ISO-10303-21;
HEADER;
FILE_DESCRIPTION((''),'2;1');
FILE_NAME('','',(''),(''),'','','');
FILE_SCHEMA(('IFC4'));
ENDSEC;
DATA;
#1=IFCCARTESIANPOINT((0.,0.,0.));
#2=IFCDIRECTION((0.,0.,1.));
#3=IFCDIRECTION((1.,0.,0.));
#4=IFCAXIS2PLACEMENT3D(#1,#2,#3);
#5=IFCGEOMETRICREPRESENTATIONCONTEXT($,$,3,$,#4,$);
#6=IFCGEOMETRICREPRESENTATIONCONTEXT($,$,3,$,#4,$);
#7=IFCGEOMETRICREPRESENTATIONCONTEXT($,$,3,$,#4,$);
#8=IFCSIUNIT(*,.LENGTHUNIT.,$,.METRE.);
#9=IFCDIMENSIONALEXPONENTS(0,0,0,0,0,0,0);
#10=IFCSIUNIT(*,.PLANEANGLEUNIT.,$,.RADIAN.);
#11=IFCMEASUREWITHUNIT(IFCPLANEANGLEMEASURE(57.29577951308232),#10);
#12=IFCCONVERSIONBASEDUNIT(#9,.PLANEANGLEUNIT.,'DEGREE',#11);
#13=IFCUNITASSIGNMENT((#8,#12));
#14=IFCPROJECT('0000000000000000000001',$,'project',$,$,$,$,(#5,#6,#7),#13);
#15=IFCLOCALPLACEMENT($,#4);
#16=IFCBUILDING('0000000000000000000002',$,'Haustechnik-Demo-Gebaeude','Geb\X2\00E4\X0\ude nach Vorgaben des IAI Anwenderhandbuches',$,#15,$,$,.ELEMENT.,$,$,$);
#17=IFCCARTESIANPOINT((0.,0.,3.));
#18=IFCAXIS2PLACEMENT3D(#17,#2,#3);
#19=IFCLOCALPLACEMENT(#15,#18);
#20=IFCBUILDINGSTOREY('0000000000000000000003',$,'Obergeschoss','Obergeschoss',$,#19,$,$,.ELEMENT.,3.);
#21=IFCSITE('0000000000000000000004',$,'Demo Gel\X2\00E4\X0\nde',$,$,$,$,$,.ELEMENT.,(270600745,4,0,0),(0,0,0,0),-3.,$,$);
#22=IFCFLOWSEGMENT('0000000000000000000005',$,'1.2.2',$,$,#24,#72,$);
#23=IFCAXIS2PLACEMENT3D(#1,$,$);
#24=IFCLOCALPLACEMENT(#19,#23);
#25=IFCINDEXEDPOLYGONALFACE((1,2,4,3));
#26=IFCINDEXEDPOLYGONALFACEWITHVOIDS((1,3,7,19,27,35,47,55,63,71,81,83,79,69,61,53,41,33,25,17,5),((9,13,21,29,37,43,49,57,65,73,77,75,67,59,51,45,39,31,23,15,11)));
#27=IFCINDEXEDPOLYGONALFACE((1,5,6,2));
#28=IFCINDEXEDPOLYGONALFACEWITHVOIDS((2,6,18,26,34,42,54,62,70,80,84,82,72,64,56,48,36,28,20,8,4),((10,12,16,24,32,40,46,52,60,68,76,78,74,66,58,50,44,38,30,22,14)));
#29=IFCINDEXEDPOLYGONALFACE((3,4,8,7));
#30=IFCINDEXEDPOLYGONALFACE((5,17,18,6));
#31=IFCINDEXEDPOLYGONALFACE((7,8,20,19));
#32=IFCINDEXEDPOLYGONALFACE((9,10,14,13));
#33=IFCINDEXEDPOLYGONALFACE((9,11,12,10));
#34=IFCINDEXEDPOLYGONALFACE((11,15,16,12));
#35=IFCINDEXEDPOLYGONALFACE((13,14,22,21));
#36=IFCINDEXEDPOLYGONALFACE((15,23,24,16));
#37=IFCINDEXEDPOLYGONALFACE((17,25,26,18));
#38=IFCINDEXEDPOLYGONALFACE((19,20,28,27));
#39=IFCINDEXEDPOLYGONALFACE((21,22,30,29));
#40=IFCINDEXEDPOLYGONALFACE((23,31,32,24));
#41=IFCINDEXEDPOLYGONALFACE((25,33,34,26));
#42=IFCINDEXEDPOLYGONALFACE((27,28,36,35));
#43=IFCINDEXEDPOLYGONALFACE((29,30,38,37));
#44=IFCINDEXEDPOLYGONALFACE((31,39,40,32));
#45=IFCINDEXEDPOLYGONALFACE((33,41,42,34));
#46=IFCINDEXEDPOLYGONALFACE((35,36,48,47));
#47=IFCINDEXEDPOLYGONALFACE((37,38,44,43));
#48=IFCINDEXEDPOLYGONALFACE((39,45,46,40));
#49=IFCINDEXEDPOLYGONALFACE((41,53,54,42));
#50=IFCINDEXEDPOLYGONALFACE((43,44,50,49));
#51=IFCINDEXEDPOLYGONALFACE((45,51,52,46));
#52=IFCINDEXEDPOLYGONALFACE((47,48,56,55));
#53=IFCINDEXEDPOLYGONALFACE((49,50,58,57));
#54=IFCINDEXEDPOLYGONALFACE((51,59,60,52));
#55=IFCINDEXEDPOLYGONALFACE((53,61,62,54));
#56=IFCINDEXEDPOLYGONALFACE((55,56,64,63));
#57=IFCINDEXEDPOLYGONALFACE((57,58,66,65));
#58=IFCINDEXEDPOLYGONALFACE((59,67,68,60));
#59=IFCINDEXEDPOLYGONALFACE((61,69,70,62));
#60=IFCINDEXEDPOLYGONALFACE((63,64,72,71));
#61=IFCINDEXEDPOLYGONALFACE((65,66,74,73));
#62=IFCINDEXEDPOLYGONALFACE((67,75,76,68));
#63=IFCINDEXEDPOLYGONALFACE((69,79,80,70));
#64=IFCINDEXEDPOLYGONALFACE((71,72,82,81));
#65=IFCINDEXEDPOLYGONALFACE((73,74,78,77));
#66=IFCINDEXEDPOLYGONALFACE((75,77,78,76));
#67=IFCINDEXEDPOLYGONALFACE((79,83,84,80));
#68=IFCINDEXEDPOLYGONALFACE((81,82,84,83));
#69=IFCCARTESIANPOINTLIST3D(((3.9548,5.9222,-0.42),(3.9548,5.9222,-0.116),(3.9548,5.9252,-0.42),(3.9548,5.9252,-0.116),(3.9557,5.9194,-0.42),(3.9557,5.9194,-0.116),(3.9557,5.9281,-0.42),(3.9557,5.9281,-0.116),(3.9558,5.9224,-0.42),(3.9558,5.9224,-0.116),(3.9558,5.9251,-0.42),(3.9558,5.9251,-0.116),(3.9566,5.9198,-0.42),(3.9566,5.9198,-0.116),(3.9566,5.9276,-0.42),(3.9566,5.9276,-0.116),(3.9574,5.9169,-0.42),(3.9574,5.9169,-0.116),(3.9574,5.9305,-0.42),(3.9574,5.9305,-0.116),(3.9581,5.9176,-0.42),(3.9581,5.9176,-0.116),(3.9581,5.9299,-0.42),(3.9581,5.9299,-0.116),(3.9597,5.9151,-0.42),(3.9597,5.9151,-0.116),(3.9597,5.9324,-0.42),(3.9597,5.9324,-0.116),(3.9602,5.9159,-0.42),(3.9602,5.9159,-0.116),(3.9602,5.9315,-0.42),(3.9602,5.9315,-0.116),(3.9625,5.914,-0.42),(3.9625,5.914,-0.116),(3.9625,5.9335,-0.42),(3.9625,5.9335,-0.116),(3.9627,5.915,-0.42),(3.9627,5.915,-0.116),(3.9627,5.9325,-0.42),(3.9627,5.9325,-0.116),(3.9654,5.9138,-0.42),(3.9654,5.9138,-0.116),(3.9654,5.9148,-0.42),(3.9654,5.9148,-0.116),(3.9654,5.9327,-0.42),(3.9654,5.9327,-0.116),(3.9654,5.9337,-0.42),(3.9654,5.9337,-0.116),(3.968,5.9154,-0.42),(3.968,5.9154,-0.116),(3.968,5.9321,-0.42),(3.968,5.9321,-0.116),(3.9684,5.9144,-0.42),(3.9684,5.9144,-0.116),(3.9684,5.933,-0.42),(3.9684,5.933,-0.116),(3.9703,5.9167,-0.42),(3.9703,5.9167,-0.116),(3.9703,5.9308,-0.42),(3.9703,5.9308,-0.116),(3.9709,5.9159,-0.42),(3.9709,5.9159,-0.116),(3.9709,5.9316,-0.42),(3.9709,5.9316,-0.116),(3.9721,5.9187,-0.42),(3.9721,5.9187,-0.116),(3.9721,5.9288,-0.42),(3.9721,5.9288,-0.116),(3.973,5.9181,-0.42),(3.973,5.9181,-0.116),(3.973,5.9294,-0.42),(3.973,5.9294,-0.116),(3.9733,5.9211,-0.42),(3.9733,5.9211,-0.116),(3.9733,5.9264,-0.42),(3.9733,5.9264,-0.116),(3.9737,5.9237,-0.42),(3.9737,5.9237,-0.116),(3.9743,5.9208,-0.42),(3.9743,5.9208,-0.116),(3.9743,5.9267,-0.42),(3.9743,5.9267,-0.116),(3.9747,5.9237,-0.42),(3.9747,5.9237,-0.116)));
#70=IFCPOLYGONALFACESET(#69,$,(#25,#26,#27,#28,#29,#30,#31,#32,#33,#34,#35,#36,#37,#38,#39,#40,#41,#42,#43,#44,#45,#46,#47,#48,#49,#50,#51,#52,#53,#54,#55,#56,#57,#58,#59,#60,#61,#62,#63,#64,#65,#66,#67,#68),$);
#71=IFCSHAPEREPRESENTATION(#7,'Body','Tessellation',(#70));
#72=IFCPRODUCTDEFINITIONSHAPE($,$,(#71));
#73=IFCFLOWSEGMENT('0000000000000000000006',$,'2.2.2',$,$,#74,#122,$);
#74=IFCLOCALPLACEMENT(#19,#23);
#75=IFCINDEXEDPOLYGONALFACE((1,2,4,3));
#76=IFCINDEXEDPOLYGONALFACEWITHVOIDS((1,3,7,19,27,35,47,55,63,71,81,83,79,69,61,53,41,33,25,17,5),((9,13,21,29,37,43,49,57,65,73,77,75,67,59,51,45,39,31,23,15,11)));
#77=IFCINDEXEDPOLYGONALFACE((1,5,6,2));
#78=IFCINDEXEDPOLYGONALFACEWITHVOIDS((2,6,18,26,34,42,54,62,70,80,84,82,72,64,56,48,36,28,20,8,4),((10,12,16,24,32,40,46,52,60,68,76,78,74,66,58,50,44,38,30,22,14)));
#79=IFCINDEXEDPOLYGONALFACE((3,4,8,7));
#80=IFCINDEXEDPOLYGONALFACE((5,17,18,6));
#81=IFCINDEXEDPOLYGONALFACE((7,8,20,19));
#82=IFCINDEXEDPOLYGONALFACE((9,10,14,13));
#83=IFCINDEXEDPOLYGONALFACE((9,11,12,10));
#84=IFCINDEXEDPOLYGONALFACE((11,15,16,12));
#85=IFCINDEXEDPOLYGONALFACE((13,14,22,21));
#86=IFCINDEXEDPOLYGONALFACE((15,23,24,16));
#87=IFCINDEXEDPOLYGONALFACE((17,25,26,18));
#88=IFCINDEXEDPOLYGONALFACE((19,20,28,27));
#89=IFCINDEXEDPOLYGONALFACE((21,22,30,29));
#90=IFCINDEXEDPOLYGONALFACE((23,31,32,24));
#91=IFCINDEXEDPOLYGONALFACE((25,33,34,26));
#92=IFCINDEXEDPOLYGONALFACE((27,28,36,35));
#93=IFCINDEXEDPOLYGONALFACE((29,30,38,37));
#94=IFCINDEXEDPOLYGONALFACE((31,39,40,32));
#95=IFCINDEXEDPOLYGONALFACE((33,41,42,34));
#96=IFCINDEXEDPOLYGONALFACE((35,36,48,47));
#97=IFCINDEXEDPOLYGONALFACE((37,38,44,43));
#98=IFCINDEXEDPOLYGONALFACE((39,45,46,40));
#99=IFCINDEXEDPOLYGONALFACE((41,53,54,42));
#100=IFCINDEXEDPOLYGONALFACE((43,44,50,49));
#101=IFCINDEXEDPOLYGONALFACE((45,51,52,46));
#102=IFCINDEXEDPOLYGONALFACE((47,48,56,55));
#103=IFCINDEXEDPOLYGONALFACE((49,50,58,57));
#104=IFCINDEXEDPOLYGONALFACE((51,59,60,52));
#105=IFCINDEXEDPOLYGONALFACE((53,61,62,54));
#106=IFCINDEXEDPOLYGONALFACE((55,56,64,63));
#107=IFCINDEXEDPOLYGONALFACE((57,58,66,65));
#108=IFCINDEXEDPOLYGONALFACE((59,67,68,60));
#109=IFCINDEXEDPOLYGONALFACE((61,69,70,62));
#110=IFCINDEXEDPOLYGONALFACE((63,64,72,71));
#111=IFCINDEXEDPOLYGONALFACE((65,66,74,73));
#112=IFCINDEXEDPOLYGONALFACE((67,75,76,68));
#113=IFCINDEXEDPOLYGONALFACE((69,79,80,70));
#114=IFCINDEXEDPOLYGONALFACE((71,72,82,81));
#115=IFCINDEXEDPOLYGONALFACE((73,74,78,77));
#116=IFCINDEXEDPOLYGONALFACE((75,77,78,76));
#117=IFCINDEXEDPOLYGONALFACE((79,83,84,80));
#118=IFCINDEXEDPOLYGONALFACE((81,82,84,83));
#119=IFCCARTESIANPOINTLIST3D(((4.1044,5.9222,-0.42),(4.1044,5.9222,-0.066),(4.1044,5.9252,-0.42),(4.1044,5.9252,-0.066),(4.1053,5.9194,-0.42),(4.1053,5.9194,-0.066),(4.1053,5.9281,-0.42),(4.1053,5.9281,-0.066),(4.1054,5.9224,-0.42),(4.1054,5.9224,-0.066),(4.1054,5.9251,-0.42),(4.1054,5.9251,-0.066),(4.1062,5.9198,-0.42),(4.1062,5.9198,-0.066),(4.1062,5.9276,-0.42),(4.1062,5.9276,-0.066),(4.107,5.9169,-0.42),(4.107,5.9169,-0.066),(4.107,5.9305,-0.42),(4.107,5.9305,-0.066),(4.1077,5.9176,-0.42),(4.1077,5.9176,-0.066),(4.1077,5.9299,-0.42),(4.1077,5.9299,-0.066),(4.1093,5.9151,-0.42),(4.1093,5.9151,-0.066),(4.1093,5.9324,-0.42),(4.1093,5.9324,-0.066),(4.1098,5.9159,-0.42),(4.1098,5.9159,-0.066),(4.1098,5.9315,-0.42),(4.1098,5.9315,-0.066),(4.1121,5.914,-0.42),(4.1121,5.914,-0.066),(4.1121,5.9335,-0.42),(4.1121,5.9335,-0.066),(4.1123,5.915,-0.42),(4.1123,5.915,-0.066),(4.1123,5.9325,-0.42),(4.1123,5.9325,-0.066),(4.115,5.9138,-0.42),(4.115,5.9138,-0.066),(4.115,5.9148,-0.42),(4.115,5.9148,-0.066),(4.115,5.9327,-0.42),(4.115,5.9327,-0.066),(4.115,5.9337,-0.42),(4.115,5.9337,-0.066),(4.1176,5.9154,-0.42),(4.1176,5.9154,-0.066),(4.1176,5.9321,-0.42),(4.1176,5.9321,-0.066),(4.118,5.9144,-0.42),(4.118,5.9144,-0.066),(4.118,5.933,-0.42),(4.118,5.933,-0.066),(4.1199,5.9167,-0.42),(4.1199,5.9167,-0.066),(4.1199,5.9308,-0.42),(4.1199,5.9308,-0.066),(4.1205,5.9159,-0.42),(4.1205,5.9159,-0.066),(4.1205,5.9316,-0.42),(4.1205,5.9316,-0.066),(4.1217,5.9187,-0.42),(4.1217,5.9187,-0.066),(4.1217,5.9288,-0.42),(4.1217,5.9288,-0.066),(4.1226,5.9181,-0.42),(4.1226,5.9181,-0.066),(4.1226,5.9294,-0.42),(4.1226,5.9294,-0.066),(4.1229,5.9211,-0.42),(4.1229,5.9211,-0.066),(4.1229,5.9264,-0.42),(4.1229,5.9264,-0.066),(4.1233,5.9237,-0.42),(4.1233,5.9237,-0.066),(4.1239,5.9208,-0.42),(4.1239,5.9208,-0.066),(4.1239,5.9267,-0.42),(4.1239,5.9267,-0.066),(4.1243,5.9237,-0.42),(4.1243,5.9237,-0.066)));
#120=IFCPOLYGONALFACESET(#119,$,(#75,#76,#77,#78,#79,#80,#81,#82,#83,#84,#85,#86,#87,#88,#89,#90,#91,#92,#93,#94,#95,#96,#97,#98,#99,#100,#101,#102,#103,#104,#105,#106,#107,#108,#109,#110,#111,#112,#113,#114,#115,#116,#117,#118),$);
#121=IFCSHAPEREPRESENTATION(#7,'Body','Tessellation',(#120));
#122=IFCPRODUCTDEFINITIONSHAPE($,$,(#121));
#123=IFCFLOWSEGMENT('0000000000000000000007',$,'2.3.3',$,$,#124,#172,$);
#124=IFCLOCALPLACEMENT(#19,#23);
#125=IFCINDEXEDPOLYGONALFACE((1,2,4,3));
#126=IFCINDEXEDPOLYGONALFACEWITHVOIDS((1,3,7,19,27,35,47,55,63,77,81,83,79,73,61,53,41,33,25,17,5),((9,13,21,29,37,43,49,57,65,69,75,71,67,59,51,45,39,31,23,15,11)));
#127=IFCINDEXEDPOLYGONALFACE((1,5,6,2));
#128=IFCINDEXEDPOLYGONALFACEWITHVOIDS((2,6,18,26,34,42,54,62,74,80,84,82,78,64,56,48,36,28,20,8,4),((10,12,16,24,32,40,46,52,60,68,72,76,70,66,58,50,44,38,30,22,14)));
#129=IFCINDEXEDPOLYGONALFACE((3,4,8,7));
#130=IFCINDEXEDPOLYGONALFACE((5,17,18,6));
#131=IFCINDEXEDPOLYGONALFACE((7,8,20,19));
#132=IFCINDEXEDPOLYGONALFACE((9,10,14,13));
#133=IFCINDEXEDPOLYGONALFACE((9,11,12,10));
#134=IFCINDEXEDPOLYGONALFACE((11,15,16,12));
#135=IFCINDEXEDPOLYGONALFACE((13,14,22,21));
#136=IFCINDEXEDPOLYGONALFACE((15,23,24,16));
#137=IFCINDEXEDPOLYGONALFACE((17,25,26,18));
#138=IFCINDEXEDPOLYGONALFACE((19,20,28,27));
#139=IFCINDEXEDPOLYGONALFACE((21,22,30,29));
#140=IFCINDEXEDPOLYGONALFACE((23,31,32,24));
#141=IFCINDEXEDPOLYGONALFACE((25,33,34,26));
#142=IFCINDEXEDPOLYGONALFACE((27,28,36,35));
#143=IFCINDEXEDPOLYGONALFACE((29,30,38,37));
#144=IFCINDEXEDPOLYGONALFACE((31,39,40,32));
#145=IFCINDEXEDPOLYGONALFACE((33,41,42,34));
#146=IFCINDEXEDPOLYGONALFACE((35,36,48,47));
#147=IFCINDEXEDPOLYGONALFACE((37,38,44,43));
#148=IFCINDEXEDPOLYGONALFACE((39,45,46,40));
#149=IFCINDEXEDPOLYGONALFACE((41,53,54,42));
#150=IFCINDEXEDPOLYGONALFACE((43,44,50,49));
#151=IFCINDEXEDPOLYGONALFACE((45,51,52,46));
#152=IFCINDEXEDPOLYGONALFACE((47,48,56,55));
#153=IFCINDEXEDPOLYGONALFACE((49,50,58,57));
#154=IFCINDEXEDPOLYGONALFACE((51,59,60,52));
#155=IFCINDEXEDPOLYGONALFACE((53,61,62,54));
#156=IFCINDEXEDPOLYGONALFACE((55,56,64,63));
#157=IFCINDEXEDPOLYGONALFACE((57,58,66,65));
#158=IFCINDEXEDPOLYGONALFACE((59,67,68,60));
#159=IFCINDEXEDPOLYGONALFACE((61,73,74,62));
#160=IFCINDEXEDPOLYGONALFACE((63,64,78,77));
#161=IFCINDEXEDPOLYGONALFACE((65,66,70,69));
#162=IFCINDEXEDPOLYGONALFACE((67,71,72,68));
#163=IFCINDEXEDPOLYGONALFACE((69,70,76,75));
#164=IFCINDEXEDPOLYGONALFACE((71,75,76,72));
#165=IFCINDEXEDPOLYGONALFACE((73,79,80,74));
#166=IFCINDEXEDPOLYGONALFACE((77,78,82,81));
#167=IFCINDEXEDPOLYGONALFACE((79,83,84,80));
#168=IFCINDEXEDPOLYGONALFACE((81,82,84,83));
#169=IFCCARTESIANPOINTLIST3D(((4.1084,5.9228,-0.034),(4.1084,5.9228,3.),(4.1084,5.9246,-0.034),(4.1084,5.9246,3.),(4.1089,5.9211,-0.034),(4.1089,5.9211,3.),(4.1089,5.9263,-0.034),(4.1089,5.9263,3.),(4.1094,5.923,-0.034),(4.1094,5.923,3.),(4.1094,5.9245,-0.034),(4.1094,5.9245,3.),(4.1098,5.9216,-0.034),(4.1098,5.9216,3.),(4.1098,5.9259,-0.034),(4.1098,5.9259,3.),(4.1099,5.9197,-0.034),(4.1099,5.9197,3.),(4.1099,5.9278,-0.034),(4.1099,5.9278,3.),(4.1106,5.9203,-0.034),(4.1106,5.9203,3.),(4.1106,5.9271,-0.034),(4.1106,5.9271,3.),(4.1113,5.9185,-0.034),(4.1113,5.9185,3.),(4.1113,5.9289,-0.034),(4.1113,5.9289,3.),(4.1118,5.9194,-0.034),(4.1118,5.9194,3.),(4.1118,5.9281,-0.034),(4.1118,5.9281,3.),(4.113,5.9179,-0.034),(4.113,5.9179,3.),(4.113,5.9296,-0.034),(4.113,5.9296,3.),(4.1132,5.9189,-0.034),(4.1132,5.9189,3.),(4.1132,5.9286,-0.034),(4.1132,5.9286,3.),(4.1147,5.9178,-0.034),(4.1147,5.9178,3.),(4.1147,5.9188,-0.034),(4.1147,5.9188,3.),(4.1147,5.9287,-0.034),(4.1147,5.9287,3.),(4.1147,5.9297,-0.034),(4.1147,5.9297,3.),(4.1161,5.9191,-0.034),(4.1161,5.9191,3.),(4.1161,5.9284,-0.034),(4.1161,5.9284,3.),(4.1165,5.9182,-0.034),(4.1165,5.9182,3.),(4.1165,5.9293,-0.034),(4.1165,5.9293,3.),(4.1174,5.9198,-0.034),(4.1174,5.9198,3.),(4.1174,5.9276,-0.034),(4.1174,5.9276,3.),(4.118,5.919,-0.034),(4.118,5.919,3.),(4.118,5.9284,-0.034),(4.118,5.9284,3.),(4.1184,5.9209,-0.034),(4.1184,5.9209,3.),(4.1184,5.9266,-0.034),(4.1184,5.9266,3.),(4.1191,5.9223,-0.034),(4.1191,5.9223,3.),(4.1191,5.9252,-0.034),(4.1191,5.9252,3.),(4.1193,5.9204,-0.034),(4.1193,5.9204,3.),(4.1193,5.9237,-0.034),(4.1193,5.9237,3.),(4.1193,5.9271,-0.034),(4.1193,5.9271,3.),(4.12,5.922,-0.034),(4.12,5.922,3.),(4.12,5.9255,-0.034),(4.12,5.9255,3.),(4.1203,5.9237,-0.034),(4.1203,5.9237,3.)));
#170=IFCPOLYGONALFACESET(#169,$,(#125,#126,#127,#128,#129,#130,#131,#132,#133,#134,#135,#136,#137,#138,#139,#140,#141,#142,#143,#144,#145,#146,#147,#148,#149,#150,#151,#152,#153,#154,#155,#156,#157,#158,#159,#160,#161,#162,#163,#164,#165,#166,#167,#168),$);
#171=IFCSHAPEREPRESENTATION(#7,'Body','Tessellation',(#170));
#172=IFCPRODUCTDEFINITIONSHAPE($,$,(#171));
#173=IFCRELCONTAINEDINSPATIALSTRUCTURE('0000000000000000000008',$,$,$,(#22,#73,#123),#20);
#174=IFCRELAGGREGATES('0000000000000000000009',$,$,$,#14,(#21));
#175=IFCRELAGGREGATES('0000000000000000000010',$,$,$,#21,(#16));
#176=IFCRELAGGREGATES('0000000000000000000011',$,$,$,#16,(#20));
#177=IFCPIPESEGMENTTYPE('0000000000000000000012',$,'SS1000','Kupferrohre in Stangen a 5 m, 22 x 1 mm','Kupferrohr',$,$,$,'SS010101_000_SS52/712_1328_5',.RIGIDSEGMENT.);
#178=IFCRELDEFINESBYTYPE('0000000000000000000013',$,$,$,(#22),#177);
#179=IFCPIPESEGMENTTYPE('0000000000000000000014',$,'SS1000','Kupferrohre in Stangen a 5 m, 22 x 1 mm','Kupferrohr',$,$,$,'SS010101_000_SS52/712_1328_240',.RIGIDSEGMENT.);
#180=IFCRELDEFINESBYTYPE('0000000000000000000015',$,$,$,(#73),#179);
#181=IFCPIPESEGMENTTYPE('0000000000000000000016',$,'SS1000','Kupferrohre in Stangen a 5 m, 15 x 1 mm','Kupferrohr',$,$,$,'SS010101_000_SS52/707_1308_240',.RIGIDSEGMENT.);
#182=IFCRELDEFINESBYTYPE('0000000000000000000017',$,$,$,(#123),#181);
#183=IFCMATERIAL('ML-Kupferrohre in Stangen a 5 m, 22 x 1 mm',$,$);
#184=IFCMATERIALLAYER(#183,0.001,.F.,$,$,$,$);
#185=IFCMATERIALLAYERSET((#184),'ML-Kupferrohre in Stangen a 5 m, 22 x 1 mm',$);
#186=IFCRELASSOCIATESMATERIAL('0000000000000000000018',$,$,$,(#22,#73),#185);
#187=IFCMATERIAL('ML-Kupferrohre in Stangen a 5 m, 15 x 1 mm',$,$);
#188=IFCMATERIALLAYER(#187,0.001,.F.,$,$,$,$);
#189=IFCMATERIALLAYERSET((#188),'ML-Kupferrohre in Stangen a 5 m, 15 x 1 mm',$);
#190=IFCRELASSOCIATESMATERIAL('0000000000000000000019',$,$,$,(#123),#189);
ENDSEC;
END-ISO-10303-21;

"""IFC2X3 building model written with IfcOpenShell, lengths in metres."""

from ifc_helpers import new_model, entity, si_unit, converted_unit, frame, origin_with_axes, origin_2d_with_axis, place, context, project, spatial, hollow_circle, extrude, material, layer, layer_set, layer_usage, type_object, element, save


model = new_model("IFC2X3")

# Units and contexts
context_of_model_1 = context(None, 3, world=origin_with_axes())
context_of_model_2 = context(None, 3, world=origin_with_axes())
context_of_model_3 = context(None, 3, world=origin_with_axes())
ifc_project = project(units=[si_unit("LENGTHUNIT", "METRE"), converted_unit("PLANEANGLEUNIT", "DEGREE", entity("IfcPlaneAngleMeasure", 57.29577951308232), si_unit("PLANEANGLEUNIT", "RADIAN"), dimensions=[0, 0, 0, 0, 0, 0, 0])], contexts=[context_of_model_1, context_of_model_2, context_of_model_3])

# Site, building, storey
site = spatial("IfcSite", under=ifc_project, Name="Demo Gelände", CompositionType="ELEMENT", RefLatitude=(270600745, 4, 0, 0), RefLongitude=(0, 0, 0, 0), RefElevation=-3.0)
building_placement = place(None, origin_with_axes())
building = spatial("IfcBuilding", under=site, at=building_placement, Name="Haustechnik-Demo-Gebaeude", Description="Gebäude nach Vorgaben des IAI Anwenderhandbuches", CompositionType="ELEMENT")
storey_placement = place(building_placement, frame((0.0, 0.0, 3.0), z_axis=(0.0, 0.0, 1.0), x_axis=(1.0, 0.0, 0.0)))
storey = spatial("IfcBuildingStorey", under=building, at=storey_placement, Name="Obergeschoss", Description="Obergeschoss", CompositionType="ELEMENT", Elevation=3.0)

# Flow segments
ifc_material_1 = material(Name="ML-Kupferrohre in Stangen a 5 m, 22 x 1 mm")
ifc_layer_1 = layer(ifc_material_1, 0.001, ventilated=False)
ifc_layer_set_1 = layer_set([ifc_layer_1], Name="ML-Kupferrohre in Stangen a 5 m, 22 x 1 mm")
ifc_layer_usage_1 = layer_usage(ifc_layer_set_1, "AXIS2", "POSITIVE", 0.0)
pipe_segment_type_1 = type_object("IfcPipeSegmentType", Name="SS1000", Description="Kupferrohre in Stangen a 5 m, 22 x 1 mm", ApplicableOccurrence="Kupferrohr", ElementType="SS010101_000_SS52/712_1328_5", PredefinedType="RIGIDSEGMENT")
flow_segment_1_placement = place(storey_placement, frame((3.9647, 5.9237, -0.42), z_axis=(0.0, 0.0, 1.0), x_axis=(1.0, 0.0, 0.0)))
element("IfcFlowSegment", 1, at=flow_segment_1_placement, inside=storey, type_object=pipe_segment_type_1, material=ifc_layer_usage_1, Name="1.2.2", context=context_of_model_3, shape_type="SweptSolid", body=[
    extrude(hollow_circle(Radius=0.01, WallThickness=0.001, at=origin_2d_with_axis()), origin_with_axes(), (0.0, 0.0, 1.0), 0.304),
])
pipe_segment_type_2 = type_object("IfcPipeSegmentType", Name="SS1000", Description="Kupferrohre in Stangen a 5 m, 22 x 1 mm", ApplicableOccurrence="Kupferrohr", ElementType="SS010101_000_SS52/712_1328_240", PredefinedType="RIGIDSEGMENT")
flow_segment_2_placement = place(storey_placement, frame((4.1143, 5.9237, -0.42), z_axis=(0.0, 0.0, 1.0), x_axis=(1.0, 0.0, 0.0)))
element("IfcFlowSegment", 2, at=flow_segment_2_placement, inside=storey, type_object=pipe_segment_type_2, material=ifc_layer_usage_1, Name="2.2.2", context=context_of_model_3, shape_type="SweptSolid", body=[
    extrude(hollow_circle(Radius=0.01, WallThickness=0.001, at=origin_2d_with_axis()), origin_with_axes(), (0.0, 0.0, 1.0), 0.354),
])
ifc_material_2 = material(Name="ML-Kupferrohre in Stangen a 5 m, 15 x 1 mm")
ifc_layer_2 = layer(ifc_material_2, 0.001, ventilated=False)
ifc_layer_set_2 = layer_set([ifc_layer_2], Name="ML-Kupferrohre in Stangen a 5 m, 15 x 1 mm")
ifc_layer_usage_2 = layer_usage(ifc_layer_set_2, "AXIS2", "POSITIVE", 0.0)
pipe_segment_type_3 = type_object("IfcPipeSegmentType", Name="SS1000", Description="Kupferrohre in Stangen a 5 m, 15 x 1 mm", ApplicableOccurrence="Kupferrohr", ElementType="SS010101_000_SS52/707_1308_240", PredefinedType="RIGIDSEGMENT")
flow_segment_3_placement = place(storey_placement, frame((4.1143, 5.9237, -0.034), z_axis=(0.0, 0.0, 1.0), x_axis=(1.0, 0.0, 0.0)))
element("IfcFlowSegment", 3, at=flow_segment_3_placement, inside=storey, type_object=pipe_segment_type_3, material=ifc_layer_usage_2, Name="2.3.3", context=context_of_model_3, shape_type="SweptSolid", body=[
    extrude(hollow_circle(Radius=0.006, WallThickness=0.001, at=origin_2d_with_axis()), origin_with_axes(), (0.0, 0.0, 1.0), 3.034),
])

save(model, "model.ifc")
